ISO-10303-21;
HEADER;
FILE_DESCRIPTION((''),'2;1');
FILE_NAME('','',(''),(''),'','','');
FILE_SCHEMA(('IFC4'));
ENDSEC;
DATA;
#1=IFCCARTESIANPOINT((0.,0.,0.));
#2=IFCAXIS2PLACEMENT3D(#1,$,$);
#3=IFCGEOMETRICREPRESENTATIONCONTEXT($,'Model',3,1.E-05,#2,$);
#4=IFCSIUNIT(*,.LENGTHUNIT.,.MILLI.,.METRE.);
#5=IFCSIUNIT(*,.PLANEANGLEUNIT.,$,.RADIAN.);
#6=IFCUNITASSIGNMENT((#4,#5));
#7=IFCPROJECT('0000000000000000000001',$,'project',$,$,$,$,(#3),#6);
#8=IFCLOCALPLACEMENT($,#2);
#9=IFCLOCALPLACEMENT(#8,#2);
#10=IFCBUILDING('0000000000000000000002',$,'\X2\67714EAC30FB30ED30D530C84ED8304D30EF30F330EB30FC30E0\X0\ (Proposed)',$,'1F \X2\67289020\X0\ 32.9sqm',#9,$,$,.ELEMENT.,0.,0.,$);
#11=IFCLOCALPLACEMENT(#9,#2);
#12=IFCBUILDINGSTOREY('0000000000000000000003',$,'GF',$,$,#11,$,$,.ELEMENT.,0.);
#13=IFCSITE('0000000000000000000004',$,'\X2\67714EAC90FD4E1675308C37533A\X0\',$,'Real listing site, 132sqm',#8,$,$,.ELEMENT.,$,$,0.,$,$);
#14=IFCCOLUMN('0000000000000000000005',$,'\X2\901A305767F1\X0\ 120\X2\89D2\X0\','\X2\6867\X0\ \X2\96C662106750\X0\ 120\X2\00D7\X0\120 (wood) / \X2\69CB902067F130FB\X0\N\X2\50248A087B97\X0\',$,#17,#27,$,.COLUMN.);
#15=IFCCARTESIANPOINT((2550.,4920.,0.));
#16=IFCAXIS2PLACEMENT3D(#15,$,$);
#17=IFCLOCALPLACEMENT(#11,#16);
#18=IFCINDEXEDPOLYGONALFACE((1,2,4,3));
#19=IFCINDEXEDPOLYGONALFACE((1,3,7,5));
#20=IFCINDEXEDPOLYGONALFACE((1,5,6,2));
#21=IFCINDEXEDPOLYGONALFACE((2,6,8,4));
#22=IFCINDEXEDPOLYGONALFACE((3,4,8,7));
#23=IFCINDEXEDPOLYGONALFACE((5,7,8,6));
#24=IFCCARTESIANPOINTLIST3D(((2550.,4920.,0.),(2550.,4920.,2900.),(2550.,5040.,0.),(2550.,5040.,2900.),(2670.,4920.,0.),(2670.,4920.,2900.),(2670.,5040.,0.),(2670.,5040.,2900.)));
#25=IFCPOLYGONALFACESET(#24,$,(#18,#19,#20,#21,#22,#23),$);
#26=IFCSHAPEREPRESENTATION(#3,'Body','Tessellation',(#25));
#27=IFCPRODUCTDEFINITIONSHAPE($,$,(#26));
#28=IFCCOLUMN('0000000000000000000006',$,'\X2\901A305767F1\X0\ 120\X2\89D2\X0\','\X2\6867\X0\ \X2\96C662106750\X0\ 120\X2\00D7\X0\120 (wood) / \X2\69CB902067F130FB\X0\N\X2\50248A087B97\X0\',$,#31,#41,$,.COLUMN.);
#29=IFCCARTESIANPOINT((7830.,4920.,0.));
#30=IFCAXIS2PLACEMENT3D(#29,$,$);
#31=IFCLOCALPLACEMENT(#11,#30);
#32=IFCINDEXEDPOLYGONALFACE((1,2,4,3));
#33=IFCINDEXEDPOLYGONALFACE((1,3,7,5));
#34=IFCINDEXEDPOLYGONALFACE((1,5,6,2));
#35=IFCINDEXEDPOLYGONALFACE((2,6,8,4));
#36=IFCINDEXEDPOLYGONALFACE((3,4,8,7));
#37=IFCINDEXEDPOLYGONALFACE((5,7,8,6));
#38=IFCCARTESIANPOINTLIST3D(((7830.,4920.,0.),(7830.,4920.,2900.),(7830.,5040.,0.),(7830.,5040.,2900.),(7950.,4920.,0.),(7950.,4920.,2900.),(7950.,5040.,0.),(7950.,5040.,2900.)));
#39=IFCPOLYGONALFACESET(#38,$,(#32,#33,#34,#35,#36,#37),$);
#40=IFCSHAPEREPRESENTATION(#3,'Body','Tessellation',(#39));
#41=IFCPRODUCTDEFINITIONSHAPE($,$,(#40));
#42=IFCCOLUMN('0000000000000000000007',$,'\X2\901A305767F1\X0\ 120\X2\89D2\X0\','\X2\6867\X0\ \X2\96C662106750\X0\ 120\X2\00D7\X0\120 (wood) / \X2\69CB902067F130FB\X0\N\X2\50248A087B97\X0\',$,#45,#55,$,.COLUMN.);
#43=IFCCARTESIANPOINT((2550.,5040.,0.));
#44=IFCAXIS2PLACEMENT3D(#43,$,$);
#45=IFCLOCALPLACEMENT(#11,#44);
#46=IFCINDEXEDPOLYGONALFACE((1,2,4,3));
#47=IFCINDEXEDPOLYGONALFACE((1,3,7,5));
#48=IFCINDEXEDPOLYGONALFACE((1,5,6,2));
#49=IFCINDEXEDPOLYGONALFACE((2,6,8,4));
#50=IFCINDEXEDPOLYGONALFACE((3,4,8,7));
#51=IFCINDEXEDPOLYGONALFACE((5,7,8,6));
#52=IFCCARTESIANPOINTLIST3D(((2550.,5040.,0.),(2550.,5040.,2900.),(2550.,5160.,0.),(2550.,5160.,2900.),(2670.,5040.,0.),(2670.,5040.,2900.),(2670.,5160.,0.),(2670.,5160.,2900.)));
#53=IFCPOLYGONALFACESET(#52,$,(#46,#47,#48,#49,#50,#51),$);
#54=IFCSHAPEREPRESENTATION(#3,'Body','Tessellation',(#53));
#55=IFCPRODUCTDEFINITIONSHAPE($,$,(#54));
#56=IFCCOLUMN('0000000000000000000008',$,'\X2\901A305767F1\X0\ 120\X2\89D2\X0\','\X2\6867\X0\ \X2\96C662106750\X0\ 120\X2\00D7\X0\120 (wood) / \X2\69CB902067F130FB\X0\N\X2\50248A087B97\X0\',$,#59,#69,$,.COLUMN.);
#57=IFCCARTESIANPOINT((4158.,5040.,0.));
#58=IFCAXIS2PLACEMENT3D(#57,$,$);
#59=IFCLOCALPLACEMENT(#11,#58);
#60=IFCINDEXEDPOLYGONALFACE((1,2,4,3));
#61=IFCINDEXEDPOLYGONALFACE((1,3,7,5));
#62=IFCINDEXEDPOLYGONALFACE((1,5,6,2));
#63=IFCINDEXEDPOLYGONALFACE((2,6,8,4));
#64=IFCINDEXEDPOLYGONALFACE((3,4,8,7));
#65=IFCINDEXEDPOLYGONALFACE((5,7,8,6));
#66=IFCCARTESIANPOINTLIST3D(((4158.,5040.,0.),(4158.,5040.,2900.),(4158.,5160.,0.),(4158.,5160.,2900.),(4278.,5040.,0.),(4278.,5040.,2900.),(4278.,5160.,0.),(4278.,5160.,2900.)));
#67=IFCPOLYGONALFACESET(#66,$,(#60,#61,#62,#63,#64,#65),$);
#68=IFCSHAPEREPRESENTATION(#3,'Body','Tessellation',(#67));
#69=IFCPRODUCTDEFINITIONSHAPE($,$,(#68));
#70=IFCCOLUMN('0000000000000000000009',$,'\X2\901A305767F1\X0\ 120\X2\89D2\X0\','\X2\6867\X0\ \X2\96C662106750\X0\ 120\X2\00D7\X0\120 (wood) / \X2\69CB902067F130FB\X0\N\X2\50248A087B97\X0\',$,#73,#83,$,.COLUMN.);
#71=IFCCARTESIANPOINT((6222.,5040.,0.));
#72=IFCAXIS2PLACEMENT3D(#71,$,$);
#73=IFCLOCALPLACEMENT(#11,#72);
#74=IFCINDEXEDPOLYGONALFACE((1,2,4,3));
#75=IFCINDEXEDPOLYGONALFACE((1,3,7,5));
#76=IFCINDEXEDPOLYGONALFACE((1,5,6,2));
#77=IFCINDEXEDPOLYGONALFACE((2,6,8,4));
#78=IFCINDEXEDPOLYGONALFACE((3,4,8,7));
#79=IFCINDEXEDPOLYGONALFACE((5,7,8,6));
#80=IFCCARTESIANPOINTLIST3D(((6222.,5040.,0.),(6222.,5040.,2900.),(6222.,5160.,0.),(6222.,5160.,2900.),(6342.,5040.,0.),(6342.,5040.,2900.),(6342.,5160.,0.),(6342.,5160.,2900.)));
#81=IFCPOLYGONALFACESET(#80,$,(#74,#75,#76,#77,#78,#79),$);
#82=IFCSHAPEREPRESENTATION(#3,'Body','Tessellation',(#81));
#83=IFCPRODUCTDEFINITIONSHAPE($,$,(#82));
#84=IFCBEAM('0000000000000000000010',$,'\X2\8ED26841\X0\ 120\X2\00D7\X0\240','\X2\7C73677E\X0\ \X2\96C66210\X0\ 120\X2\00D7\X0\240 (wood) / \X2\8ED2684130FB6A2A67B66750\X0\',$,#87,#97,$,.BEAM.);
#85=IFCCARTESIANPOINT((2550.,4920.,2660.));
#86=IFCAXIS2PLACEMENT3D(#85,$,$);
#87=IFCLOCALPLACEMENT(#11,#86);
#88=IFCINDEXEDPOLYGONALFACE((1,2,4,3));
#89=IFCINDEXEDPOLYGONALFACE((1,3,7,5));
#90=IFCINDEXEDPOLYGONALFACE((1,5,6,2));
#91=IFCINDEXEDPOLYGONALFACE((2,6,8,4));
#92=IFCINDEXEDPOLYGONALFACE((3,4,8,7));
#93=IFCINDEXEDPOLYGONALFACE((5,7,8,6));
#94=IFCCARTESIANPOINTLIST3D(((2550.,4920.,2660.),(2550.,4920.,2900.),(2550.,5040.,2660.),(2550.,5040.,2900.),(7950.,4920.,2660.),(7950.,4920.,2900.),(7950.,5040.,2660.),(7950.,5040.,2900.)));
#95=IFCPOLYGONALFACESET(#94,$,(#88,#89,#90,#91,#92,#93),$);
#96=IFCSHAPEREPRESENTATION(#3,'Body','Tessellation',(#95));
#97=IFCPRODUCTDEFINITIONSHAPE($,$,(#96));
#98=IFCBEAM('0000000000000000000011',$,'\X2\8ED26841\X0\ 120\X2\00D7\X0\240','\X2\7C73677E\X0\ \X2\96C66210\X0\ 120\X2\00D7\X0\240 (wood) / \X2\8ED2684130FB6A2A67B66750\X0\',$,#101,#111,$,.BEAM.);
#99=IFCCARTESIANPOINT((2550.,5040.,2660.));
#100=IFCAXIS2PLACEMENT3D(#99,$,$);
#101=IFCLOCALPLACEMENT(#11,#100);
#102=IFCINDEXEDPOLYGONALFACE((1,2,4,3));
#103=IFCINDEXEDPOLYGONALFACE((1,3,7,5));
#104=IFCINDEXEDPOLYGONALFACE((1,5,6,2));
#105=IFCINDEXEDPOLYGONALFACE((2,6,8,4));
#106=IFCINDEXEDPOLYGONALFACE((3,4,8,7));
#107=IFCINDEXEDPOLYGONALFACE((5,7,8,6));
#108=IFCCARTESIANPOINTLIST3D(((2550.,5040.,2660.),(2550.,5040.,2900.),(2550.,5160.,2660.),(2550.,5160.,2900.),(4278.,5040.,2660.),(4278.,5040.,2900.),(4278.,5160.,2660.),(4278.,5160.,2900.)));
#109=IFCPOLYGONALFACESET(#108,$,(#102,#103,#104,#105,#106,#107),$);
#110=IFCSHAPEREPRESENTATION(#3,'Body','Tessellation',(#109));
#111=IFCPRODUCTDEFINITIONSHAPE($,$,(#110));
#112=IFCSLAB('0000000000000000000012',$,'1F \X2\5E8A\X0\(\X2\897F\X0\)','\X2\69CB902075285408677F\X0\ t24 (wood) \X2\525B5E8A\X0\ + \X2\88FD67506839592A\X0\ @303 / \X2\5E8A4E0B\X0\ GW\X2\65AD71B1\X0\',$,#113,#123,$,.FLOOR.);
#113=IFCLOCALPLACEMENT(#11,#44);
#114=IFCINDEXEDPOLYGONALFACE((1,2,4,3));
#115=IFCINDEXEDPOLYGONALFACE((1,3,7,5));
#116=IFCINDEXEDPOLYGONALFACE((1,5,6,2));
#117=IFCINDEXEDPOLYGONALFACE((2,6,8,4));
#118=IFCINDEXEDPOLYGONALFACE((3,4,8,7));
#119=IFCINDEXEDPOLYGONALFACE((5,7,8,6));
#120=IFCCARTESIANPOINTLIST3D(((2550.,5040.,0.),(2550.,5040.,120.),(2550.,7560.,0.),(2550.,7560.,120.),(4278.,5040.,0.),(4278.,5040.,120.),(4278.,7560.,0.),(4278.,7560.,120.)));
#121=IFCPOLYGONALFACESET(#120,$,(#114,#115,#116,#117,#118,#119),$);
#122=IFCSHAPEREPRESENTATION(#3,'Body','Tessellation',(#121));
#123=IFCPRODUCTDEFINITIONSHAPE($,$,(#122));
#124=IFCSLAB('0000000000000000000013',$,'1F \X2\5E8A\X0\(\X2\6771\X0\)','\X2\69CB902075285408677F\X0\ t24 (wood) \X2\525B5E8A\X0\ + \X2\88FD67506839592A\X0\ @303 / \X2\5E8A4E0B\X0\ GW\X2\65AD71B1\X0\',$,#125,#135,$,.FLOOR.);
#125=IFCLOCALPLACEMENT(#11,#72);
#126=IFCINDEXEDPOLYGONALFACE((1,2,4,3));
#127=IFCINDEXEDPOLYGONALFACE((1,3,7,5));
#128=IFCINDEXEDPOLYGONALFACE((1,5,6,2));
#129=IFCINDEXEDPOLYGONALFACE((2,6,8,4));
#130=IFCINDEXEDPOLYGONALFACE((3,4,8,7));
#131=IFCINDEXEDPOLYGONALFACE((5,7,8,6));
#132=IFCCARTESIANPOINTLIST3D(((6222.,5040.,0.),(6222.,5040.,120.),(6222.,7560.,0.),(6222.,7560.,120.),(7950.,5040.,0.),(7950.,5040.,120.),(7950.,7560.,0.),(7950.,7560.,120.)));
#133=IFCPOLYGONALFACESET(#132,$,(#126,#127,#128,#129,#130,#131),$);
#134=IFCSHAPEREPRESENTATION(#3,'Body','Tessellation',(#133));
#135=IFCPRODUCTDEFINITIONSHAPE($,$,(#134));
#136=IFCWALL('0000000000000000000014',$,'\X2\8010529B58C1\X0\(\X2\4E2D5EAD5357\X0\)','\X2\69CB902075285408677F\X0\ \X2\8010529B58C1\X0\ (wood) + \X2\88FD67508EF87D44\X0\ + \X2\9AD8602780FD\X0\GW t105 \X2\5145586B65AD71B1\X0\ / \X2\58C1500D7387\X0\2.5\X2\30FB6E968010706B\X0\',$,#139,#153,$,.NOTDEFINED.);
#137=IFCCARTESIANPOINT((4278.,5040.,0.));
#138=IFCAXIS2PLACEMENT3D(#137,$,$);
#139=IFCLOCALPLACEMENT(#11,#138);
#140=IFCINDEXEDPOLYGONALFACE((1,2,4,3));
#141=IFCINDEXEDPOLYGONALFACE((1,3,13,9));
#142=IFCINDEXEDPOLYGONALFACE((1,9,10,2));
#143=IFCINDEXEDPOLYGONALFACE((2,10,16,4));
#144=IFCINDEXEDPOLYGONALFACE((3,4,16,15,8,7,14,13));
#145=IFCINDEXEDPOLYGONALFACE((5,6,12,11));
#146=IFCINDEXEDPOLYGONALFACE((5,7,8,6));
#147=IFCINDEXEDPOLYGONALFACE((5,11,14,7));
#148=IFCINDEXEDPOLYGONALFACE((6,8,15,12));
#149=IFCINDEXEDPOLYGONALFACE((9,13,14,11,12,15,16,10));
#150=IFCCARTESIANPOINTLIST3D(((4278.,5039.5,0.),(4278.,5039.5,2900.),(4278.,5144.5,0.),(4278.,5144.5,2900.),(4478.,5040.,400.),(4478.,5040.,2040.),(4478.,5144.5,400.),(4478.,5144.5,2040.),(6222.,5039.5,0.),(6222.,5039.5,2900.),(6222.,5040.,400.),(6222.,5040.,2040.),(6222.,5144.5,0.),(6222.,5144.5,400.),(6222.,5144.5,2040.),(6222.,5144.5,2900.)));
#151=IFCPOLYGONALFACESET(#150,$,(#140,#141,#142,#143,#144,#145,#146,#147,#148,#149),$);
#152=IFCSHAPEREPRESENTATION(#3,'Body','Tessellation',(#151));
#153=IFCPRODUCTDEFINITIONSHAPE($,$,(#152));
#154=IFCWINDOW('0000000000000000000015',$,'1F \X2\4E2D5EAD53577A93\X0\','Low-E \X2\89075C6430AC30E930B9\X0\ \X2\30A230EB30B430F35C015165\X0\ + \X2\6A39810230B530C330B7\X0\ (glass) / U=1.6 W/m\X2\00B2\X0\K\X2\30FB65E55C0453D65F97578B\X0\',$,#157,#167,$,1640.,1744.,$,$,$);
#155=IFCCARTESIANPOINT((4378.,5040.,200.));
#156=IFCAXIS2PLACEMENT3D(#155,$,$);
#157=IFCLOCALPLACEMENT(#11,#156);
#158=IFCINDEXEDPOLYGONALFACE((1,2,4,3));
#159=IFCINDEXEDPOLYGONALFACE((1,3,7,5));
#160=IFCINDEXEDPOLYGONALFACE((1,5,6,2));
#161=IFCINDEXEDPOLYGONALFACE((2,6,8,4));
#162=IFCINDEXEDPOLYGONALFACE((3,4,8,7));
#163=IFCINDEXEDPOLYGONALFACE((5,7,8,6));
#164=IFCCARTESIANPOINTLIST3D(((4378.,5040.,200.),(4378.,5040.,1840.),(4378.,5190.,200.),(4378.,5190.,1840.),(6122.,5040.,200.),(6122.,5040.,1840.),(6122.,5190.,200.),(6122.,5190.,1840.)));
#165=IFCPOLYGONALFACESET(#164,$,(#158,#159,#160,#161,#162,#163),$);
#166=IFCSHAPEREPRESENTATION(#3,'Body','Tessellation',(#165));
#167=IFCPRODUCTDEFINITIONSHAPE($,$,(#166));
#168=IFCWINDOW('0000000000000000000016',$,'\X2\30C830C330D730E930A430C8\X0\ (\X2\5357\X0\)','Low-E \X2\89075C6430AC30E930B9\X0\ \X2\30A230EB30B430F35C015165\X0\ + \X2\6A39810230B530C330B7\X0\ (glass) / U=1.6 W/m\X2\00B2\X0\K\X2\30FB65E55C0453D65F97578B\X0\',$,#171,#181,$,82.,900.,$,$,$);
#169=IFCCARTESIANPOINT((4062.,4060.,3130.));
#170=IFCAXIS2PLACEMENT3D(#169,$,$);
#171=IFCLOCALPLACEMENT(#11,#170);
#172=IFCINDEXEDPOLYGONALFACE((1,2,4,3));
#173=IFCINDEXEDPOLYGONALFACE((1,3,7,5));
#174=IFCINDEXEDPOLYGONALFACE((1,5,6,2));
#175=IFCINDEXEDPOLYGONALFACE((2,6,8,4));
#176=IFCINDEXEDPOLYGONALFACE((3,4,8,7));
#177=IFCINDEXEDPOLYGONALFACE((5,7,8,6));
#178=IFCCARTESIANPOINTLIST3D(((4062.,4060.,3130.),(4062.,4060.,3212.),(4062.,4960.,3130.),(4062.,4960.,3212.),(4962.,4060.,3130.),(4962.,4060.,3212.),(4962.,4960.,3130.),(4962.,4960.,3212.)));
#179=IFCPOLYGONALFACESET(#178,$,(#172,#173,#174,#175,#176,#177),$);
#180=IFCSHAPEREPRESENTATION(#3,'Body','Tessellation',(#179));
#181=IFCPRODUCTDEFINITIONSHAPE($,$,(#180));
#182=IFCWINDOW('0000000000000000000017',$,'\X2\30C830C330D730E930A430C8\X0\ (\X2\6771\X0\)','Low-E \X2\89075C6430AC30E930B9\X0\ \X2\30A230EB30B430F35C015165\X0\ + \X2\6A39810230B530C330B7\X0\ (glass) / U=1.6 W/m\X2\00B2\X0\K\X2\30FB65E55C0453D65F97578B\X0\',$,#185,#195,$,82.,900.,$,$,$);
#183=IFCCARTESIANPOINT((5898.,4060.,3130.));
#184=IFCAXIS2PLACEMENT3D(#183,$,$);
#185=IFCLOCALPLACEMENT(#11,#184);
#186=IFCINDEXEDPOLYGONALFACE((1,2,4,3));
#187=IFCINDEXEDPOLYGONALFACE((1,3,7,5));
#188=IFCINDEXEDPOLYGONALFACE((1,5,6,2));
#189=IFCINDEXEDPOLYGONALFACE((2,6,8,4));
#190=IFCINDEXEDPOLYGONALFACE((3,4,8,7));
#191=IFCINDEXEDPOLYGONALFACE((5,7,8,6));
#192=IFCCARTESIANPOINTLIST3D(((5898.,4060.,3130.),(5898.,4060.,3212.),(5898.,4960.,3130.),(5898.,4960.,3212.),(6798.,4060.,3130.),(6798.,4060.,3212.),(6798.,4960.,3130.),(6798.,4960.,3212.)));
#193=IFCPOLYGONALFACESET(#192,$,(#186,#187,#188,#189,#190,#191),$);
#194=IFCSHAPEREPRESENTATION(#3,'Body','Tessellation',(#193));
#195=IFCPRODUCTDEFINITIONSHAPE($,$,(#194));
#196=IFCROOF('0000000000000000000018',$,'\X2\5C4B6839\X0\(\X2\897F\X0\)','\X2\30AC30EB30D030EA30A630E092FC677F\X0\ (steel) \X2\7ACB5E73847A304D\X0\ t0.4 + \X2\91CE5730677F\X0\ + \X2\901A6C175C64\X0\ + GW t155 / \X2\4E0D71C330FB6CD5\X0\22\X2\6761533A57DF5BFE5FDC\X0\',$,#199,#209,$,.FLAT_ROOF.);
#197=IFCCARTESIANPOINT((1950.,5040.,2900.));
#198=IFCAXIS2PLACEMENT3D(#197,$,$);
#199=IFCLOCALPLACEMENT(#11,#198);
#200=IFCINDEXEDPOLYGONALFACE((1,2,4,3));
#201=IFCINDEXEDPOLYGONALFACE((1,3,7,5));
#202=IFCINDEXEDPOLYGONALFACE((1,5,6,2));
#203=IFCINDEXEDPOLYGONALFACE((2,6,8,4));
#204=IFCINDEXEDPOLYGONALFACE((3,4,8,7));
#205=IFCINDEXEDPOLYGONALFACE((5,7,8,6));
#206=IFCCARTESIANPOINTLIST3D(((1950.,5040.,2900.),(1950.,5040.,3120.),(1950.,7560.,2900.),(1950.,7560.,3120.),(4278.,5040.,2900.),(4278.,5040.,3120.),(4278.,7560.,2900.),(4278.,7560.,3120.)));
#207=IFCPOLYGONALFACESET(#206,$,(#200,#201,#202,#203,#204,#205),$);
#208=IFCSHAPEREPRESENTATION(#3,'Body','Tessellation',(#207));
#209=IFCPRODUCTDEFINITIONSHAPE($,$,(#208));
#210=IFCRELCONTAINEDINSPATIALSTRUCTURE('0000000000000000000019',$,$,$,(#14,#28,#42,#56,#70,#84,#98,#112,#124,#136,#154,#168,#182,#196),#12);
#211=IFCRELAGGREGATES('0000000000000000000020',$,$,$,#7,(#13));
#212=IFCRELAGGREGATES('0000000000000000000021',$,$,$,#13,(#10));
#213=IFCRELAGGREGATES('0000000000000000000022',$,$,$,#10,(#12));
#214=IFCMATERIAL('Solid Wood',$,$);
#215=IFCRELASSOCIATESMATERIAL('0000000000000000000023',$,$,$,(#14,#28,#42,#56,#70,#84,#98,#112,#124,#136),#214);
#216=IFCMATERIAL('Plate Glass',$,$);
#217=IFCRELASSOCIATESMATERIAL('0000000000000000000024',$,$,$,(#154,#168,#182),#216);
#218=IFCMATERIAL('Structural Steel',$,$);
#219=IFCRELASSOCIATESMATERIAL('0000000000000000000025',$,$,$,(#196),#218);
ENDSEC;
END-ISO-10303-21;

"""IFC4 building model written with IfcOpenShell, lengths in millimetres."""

from ifc_helpers import new_model, si_unit, frame, frame_2d, origin, place, context, project, spatial, rectangle, extrude, material, element, fill, save


model = new_model("IFC4")

# Units and contexts
model_context = context("Model", 3, precision=1e-05, world=origin())
ifc_project = project(units=[si_unit("LENGTHUNIT", "METRE", prefix="MILLI"), si_unit("PLANEANGLEUNIT", "RADIAN")], contexts=[model_context])

# Site, building, storey
site_placement = place(None, origin())
site = spatial("IfcSite", under=ifc_project, at=site_placement, Name="東京都世田谷区", ObjectType="Real listing site, 132sqm", CompositionType="ELEMENT", RefElevation=0.0)
building_placement = place(site_placement, origin())
building = spatial("IfcBuilding", under=site, at=building_placement, Name="東京・ロフト付きワンルーム (Proposed)", ObjectType="1F 木造 32.9sqm", CompositionType="ELEMENT", ElevationOfRefHeight=0.0, ElevationOfTerrain=0.0)
storey_placement = place(building_placement, origin())
storey = spatial("IfcBuildingStorey", under=building, at=storey_placement, Name="GF", CompositionType="ELEMENT", Elevation=0.0)

# Columns
ifc_material_1 = material(Name="Solid Wood")
column_1_placement = place(storey_placement, frame((2550.0, 4920.0, 0.0)))
element("IfcColumn", 1, at=column_1_placement, inside=storey, material=ifc_material_1, Name="通し柱 120角", Description="桧 集成材 120×120 (wood) / 構造柱・N値計算", PredefinedType="COLUMN", context=model_context, shape_type="SweptSolid", body=[
    extrude(rectangle(XDim=120.0, YDim=120.0, at=frame_2d((60.0, 60.0))), frame((2550.0, 4920.0, 0.0)), (0.0, 0.0, 1.0), 2900.0),
])
column_2_placement = place(storey_placement, frame((7830.0, 4920.0, 0.0)))
element("IfcColumn", 2, at=column_2_placement, inside=storey, material=ifc_material_1, Name="通し柱 120角", Description="桧 集成材 120×120 (wood) / 構造柱・N値計算", PredefinedType="COLUMN", context=model_context, shape_type="SweptSolid", body=[
    extrude(rectangle(XDim=120.0, YDim=120.0, at=frame_2d((60.0, 60.0))), frame((7830.0, 4920.0, 0.0)), (0.0, 0.0, 1.0), 2900.0),
])
column_3_placement = place(storey_placement, frame((2550.0, 5040.0, 0.0)))
element("IfcColumn", 3, at=column_3_placement, inside=storey, material=ifc_material_1, Name="通し柱 120角", Description="桧 集成材 120×120 (wood) / 構造柱・N値計算", PredefinedType="COLUMN", context=model_context, shape_type="SweptSolid", body=[
    extrude(rectangle(XDim=120.0, YDim=120.0, at=frame_2d((60.0, 60.0))), frame((2550.0, 5040.0, 0.0)), (0.0, 0.0, 1.0), 2900.0),
])
column_4_placement = place(storey_placement, frame((4158.0, 5040.0, 0.0)))
element("IfcColumn", 4, at=column_4_placement, inside=storey, material=ifc_material_1, Name="通し柱 120角", Description="桧 集成材 120×120 (wood) / 構造柱・N値計算", PredefinedType="COLUMN", context=model_context, shape_type="SweptSolid", body=[
    extrude(rectangle(XDim=120.0, YDim=120.0, at=frame_2d((60.0, 60.0))), frame((4158.0, 5040.0, 0.0)), (0.0, 0.0, 1.0), 2900.0),
])
column_5_placement = place(storey_placement, frame((6222.0, 5040.0, 0.0)))
element("IfcColumn", 5, at=column_5_placement, inside=storey, material=ifc_material_1, Name="通し柱 120角", Description="桧 集成材 120×120 (wood) / 構造柱・N値計算", PredefinedType="COLUMN", context=model_context, shape_type="SweptSolid", body=[
    extrude(rectangle(XDim=120.0, YDim=120.0, at=frame_2d((60.0, 60.0))), frame((6222.0, 5040.0, 0.0)), (0.0, 0.0, 1.0), 2900.0),
])

# Beams
beam_1_placement = place(storey_placement, frame((2550.0, 4920.0, 2660.0)))
element("IfcBeam", 6, at=beam_1_placement, inside=storey, material=ifc_material_1, Name="軒桁 120×240", Description="米松 集成 120×240 (wood) / 軒桁・横架材", PredefinedType="BEAM", context=model_context, shape_type="SweptSolid", body=[
    extrude(rectangle(XDim=5400.0, YDim=120.0, at=frame_2d((2700.0, 60.0))), frame((2550.0, 4920.0, 2660.0)), (0.0, 0.0, 1.0), 240.0),
])
beam_2_placement = place(storey_placement, frame((2550.0, 5040.0, 2660.0)))
element("IfcBeam", 7, at=beam_2_placement, inside=storey, material=ifc_material_1, Name="軒桁 120×240", Description="米松 集成 120×240 (wood) / 軒桁・横架材", PredefinedType="BEAM", context=model_context, shape_type="SweptSolid", body=[
    extrude(rectangle(XDim=1728.0, YDim=120.0, at=frame_2d((864.0, 60.0))), frame((2550.0, 5040.0, 2660.0)), (0.0, 0.0, 1.0), 240.0),
])

# Slabs
slab_1_placement = place(storey_placement, frame((2550.0, 5040.0, 0.0)))
element("IfcSlab", 8, at=slab_1_placement, inside=storey, material=ifc_material_1, Name="1F 床(西)", Description="構造用合板 t24 (wood) 剛床 + 製材根太 @303 / 床下 GW断熱", PredefinedType="FLOOR", context=model_context, shape_type="SweptSolid", body=[
    extrude(rectangle(XDim=1728.0, YDim=2520.0, at=frame_2d((864.0, 1260.0))), frame((2550.0, 5040.0, 0.0)), (0.0, 0.0, 1.0), 120.0),
])
slab_2_placement = place(storey_placement, frame((6222.0, 5040.0, 0.0)))
element("IfcSlab", 9, at=slab_2_placement, inside=storey, material=ifc_material_1, Name="1F 床(東)", Description="構造用合板 t24 (wood) 剛床 + 製材根太 @303 / 床下 GW断熱", PredefinedType="FLOOR", context=model_context, shape_type="SweptSolid", body=[
    extrude(rectangle(XDim=1728.0, YDim=2520.0, at=frame_2d((864.0, 1260.0))), frame((6222.0, 5040.0, 0.0)), (0.0, 0.0, 1.0), 120.0),
])

# Wall, opening, window
wall_1_placement = place(storey_placement, frame((4278.0, 5040.0, 0.0)))
wall_1 = element("IfcWall", 10, at=wall_1_placement, inside=storey, material=ifc_material_1, Name="耐力壁(中庭南)", Description="構造用合板 耐力壁 (wood) + 製材軸組 + 高性能GW t105 充填断熱 / 壁倍率2.5・準耐火", PredefinedType="NOTDEFINED", context=model_context, shape_type="SweptSolid", body=[
    extrude(rectangle(XDim=1944.0, YDim=105.0, at=frame_2d((972.0, 52.0))), frame((4278.0, 5040.0, 0.0)), (0.0, 0.0, 1.0), 2900.0),
])
opening_placement = place(storey_placement, frame((4378.0, 5040.0, 200.0)))
opening = element("IfcOpeningElement", 11, at=opening_placement, cuts=wall_1, PredefinedType="NOTDEFINED", context=model_context, shape_type="SweptSolid", body=[
    extrude(rectangle(XDim=1744.0, YDim=150.0, at=frame_2d((872.0, 75.0))), frame((4378.0, 5040.0, 200.0)), (0.0, 0.0, 1.0), 1640.0),
])
ifc_material_2 = material(Name="Plate Glass")
window_1_placement = place(storey_placement, frame((4378.0, 5040.0, 200.0)))
window_1 = element("IfcWindow", 12, at=window_1_placement, inside=storey, material=ifc_material_2, Name="1F 中庭南窓", Description="Low-E 複層ガラス アルゴン封入 + 樹脂サッシ (glass) / U=1.6 W/m²K・日射取得型", OverallHeight=1640.0, OverallWidth=1744.0, context=model_context, shape_type="SweptSolid", body=[
    extrude(rectangle(XDim=1744.0, YDim=150.0, at=frame_2d((872.0, 75.0))), frame((4378.0, 5040.0, 200.0)), (0.0, 0.0, 1.0), 1640.0),
])
fill(opening, window_1)

# Windows
window_2_placement = place(storey_placement, frame((4062.0, 4060.0, 3130.0)))
element("IfcWindow", 13, at=window_2_placement, inside=storey, material=ifc_material_2, Name="トップライト (南)", Description="Low-E 複層ガラス アルゴン封入 + 樹脂サッシ (glass) / U=1.6 W/m²K・日射取得型", OverallHeight=82.0, OverallWidth=900.0, context=model_context, shape_type="SweptSolid", body=[
    extrude(rectangle(XDim=900.0, YDim=900.0, at=frame_2d((450.0, 450.0))), frame((4062.0, 4060.0, 3130.0)), (0.0, 0.0, 1.0), 82.0),
])
window_3_placement = place(storey_placement, frame((5898.0, 4060.0, 3130.0)))
element("IfcWindow", 14, at=window_3_placement, inside=storey, material=ifc_material_2, Name="トップライト (東)", Description="Low-E 複層ガラス アルゴン封入 + 樹脂サッシ (glass) / U=1.6 W/m²K・日射取得型", OverallHeight=82.0, OverallWidth=900.0, context=model_context, shape_type="SweptSolid", body=[
    extrude(rectangle(XDim=900.0, YDim=900.0, at=frame_2d((450.0, 450.0))), frame((5898.0, 4060.0, 3130.0)), (0.0, 0.0, 1.0), 82.0),
])

# Roof
ifc_material_3 = material(Name="Structural Steel")
roof_1_placement = place(storey_placement, frame((1950.0, 5040.0, 2900.0)))
element("IfcRoof", 15, at=roof_1_placement, inside=storey, material=ifc_material_3, Name="屋根(西)", Description="ガルバリウム鋼板 (steel) 立平葺き t0.4 + 野地板 + 通気層 + GW t155 / 不燃・法22条区域対応", PredefinedType="FLAT_ROOF", context=model_context, shape_type="SweptSolid", body=[
    extrude(rectangle(XDim=2328.0, YDim=2520.0, at=frame_2d((1164.0, 1260.0))), frame((1950.0, 5040.0, 2900.0)), (0.0, 0.0, 1.0), 220.0),
])

save(model, "model.ifc")
